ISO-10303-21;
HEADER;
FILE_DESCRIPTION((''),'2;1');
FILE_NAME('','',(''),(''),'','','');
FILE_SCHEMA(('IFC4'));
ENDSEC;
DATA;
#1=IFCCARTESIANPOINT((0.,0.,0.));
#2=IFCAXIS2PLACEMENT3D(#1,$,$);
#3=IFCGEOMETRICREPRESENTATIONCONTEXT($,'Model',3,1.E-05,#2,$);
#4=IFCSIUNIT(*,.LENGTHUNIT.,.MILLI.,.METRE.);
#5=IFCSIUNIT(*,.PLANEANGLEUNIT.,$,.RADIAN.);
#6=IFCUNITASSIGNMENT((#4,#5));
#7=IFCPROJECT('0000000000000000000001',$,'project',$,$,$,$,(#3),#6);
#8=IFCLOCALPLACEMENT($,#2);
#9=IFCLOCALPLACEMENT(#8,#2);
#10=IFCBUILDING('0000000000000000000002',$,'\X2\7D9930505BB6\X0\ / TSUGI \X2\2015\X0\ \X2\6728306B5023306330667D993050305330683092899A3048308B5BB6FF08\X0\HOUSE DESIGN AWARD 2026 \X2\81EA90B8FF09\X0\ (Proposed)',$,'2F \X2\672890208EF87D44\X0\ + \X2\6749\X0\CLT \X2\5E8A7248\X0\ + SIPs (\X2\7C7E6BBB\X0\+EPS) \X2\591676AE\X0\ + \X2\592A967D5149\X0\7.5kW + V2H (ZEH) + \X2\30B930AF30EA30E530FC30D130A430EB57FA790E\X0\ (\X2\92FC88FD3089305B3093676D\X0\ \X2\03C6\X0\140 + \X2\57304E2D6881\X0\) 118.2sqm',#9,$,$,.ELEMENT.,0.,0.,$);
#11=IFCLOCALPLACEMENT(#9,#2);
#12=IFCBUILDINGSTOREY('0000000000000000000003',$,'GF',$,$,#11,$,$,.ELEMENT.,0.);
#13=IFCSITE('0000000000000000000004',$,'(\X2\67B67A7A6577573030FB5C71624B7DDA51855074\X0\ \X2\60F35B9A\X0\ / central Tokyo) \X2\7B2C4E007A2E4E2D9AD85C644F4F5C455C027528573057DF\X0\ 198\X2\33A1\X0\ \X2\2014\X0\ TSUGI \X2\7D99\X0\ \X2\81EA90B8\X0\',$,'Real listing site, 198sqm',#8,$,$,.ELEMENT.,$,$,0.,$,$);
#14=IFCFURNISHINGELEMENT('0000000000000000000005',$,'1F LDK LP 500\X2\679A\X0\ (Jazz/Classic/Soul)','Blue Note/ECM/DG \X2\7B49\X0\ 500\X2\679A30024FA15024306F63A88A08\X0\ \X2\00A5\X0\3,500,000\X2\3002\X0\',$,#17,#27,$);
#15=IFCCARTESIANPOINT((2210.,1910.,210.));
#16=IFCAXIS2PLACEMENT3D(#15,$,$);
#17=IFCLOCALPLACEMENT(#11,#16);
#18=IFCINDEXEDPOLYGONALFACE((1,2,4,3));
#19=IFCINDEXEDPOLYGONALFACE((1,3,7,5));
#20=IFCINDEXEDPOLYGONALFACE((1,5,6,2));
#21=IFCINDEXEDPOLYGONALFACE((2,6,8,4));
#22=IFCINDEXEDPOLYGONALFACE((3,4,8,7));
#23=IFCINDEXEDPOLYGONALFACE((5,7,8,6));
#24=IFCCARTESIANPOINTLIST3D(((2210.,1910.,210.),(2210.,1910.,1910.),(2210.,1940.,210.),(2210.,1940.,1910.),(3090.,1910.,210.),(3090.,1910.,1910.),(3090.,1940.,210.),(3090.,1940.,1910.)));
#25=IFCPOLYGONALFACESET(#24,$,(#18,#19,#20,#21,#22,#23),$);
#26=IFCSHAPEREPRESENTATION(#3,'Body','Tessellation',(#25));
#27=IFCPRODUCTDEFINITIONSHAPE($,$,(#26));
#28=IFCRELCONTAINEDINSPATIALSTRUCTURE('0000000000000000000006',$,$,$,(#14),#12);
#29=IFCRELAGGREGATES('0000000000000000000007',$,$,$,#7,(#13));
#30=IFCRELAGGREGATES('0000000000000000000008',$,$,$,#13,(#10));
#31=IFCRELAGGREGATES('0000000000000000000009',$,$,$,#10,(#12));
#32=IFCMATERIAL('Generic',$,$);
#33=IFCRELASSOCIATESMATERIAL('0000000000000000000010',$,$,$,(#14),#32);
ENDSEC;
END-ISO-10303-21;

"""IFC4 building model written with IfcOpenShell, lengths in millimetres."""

from ifc_helpers import new_model, si_unit, frame, frame_2d, origin, place, context, project, spatial, rectangle, extrude, material, element, save


model = new_model("IFC4")

# Units and contexts
model_context = context("Model", 3, precision=1e-05, world=origin())
ifc_project = project(units=[si_unit("LENGTHUNIT", "METRE", prefix="MILLI"), si_unit("PLANEANGLEUNIT", "RADIAN")], contexts=[model_context])

# Site, building, storey
site_placement = place(None, origin())
site = spatial("IfcSite", under=ifc_project, at=site_placement, Name="(架空敷地・山手線内側 想定 / central Tokyo) 第一種中高層住居専用地域 198㎡ — TSUGI 継 自邸", ObjectType="Real listing site, 198sqm", CompositionType="ELEMENT", RefElevation=0.0)
building_placement = place(site_placement, origin())
building = spatial("IfcBuilding", under=site, at=building_placement, Name="継ぐ家 / TSUGI ― 木に倣って継ぐことを覚える家（HOUSE DESIGN AWARD 2026 自邸） (Proposed)", ObjectType="2F 木造軸組 + 杉CLT 床版 + SIPs (籾殻+EPS) 外皮 + 太陽光7.5kW + V2H (ZEH) + スクリューパイル基礎 (鋼製らせん杭 φ140 + 地中梁) 118.2sqm", CompositionType="ELEMENT", ElevationOfRefHeight=0.0, ElevationOfTerrain=0.0)
storey_placement = place(building_placement, origin())
storey = spatial("IfcBuildingStorey", under=building, at=storey_placement, Name="GF", CompositionType="ELEMENT", Elevation=0.0)

# Shared definitions
ifc_material_1 = material(Name="Generic")

# Furnishing element
furnishing_1_placement = place(storey_placement, frame((2210.0, 1910.0, 210.0)))
element("IfcFurnishingElement", 1, at=furnishing_1_placement, inside=storey, material=ifc_material_1, Name="1F LDK LP 500枚 (Jazz/Classic/Soul)", Description="Blue Note/ECM/DG 等 500枚。価値は推計 ¥3,500,000。", context=model_context, shape_type="SweptSolid", body=[
    extrude(rectangle(XDim=880.0, YDim=30.0, at=frame_2d((440.0, 15.0))), frame((2210.0, 1910.0, 210.0)), (0.0, 0.0, 1.0), 1700.0),
])

save(model, "model.ifc")
